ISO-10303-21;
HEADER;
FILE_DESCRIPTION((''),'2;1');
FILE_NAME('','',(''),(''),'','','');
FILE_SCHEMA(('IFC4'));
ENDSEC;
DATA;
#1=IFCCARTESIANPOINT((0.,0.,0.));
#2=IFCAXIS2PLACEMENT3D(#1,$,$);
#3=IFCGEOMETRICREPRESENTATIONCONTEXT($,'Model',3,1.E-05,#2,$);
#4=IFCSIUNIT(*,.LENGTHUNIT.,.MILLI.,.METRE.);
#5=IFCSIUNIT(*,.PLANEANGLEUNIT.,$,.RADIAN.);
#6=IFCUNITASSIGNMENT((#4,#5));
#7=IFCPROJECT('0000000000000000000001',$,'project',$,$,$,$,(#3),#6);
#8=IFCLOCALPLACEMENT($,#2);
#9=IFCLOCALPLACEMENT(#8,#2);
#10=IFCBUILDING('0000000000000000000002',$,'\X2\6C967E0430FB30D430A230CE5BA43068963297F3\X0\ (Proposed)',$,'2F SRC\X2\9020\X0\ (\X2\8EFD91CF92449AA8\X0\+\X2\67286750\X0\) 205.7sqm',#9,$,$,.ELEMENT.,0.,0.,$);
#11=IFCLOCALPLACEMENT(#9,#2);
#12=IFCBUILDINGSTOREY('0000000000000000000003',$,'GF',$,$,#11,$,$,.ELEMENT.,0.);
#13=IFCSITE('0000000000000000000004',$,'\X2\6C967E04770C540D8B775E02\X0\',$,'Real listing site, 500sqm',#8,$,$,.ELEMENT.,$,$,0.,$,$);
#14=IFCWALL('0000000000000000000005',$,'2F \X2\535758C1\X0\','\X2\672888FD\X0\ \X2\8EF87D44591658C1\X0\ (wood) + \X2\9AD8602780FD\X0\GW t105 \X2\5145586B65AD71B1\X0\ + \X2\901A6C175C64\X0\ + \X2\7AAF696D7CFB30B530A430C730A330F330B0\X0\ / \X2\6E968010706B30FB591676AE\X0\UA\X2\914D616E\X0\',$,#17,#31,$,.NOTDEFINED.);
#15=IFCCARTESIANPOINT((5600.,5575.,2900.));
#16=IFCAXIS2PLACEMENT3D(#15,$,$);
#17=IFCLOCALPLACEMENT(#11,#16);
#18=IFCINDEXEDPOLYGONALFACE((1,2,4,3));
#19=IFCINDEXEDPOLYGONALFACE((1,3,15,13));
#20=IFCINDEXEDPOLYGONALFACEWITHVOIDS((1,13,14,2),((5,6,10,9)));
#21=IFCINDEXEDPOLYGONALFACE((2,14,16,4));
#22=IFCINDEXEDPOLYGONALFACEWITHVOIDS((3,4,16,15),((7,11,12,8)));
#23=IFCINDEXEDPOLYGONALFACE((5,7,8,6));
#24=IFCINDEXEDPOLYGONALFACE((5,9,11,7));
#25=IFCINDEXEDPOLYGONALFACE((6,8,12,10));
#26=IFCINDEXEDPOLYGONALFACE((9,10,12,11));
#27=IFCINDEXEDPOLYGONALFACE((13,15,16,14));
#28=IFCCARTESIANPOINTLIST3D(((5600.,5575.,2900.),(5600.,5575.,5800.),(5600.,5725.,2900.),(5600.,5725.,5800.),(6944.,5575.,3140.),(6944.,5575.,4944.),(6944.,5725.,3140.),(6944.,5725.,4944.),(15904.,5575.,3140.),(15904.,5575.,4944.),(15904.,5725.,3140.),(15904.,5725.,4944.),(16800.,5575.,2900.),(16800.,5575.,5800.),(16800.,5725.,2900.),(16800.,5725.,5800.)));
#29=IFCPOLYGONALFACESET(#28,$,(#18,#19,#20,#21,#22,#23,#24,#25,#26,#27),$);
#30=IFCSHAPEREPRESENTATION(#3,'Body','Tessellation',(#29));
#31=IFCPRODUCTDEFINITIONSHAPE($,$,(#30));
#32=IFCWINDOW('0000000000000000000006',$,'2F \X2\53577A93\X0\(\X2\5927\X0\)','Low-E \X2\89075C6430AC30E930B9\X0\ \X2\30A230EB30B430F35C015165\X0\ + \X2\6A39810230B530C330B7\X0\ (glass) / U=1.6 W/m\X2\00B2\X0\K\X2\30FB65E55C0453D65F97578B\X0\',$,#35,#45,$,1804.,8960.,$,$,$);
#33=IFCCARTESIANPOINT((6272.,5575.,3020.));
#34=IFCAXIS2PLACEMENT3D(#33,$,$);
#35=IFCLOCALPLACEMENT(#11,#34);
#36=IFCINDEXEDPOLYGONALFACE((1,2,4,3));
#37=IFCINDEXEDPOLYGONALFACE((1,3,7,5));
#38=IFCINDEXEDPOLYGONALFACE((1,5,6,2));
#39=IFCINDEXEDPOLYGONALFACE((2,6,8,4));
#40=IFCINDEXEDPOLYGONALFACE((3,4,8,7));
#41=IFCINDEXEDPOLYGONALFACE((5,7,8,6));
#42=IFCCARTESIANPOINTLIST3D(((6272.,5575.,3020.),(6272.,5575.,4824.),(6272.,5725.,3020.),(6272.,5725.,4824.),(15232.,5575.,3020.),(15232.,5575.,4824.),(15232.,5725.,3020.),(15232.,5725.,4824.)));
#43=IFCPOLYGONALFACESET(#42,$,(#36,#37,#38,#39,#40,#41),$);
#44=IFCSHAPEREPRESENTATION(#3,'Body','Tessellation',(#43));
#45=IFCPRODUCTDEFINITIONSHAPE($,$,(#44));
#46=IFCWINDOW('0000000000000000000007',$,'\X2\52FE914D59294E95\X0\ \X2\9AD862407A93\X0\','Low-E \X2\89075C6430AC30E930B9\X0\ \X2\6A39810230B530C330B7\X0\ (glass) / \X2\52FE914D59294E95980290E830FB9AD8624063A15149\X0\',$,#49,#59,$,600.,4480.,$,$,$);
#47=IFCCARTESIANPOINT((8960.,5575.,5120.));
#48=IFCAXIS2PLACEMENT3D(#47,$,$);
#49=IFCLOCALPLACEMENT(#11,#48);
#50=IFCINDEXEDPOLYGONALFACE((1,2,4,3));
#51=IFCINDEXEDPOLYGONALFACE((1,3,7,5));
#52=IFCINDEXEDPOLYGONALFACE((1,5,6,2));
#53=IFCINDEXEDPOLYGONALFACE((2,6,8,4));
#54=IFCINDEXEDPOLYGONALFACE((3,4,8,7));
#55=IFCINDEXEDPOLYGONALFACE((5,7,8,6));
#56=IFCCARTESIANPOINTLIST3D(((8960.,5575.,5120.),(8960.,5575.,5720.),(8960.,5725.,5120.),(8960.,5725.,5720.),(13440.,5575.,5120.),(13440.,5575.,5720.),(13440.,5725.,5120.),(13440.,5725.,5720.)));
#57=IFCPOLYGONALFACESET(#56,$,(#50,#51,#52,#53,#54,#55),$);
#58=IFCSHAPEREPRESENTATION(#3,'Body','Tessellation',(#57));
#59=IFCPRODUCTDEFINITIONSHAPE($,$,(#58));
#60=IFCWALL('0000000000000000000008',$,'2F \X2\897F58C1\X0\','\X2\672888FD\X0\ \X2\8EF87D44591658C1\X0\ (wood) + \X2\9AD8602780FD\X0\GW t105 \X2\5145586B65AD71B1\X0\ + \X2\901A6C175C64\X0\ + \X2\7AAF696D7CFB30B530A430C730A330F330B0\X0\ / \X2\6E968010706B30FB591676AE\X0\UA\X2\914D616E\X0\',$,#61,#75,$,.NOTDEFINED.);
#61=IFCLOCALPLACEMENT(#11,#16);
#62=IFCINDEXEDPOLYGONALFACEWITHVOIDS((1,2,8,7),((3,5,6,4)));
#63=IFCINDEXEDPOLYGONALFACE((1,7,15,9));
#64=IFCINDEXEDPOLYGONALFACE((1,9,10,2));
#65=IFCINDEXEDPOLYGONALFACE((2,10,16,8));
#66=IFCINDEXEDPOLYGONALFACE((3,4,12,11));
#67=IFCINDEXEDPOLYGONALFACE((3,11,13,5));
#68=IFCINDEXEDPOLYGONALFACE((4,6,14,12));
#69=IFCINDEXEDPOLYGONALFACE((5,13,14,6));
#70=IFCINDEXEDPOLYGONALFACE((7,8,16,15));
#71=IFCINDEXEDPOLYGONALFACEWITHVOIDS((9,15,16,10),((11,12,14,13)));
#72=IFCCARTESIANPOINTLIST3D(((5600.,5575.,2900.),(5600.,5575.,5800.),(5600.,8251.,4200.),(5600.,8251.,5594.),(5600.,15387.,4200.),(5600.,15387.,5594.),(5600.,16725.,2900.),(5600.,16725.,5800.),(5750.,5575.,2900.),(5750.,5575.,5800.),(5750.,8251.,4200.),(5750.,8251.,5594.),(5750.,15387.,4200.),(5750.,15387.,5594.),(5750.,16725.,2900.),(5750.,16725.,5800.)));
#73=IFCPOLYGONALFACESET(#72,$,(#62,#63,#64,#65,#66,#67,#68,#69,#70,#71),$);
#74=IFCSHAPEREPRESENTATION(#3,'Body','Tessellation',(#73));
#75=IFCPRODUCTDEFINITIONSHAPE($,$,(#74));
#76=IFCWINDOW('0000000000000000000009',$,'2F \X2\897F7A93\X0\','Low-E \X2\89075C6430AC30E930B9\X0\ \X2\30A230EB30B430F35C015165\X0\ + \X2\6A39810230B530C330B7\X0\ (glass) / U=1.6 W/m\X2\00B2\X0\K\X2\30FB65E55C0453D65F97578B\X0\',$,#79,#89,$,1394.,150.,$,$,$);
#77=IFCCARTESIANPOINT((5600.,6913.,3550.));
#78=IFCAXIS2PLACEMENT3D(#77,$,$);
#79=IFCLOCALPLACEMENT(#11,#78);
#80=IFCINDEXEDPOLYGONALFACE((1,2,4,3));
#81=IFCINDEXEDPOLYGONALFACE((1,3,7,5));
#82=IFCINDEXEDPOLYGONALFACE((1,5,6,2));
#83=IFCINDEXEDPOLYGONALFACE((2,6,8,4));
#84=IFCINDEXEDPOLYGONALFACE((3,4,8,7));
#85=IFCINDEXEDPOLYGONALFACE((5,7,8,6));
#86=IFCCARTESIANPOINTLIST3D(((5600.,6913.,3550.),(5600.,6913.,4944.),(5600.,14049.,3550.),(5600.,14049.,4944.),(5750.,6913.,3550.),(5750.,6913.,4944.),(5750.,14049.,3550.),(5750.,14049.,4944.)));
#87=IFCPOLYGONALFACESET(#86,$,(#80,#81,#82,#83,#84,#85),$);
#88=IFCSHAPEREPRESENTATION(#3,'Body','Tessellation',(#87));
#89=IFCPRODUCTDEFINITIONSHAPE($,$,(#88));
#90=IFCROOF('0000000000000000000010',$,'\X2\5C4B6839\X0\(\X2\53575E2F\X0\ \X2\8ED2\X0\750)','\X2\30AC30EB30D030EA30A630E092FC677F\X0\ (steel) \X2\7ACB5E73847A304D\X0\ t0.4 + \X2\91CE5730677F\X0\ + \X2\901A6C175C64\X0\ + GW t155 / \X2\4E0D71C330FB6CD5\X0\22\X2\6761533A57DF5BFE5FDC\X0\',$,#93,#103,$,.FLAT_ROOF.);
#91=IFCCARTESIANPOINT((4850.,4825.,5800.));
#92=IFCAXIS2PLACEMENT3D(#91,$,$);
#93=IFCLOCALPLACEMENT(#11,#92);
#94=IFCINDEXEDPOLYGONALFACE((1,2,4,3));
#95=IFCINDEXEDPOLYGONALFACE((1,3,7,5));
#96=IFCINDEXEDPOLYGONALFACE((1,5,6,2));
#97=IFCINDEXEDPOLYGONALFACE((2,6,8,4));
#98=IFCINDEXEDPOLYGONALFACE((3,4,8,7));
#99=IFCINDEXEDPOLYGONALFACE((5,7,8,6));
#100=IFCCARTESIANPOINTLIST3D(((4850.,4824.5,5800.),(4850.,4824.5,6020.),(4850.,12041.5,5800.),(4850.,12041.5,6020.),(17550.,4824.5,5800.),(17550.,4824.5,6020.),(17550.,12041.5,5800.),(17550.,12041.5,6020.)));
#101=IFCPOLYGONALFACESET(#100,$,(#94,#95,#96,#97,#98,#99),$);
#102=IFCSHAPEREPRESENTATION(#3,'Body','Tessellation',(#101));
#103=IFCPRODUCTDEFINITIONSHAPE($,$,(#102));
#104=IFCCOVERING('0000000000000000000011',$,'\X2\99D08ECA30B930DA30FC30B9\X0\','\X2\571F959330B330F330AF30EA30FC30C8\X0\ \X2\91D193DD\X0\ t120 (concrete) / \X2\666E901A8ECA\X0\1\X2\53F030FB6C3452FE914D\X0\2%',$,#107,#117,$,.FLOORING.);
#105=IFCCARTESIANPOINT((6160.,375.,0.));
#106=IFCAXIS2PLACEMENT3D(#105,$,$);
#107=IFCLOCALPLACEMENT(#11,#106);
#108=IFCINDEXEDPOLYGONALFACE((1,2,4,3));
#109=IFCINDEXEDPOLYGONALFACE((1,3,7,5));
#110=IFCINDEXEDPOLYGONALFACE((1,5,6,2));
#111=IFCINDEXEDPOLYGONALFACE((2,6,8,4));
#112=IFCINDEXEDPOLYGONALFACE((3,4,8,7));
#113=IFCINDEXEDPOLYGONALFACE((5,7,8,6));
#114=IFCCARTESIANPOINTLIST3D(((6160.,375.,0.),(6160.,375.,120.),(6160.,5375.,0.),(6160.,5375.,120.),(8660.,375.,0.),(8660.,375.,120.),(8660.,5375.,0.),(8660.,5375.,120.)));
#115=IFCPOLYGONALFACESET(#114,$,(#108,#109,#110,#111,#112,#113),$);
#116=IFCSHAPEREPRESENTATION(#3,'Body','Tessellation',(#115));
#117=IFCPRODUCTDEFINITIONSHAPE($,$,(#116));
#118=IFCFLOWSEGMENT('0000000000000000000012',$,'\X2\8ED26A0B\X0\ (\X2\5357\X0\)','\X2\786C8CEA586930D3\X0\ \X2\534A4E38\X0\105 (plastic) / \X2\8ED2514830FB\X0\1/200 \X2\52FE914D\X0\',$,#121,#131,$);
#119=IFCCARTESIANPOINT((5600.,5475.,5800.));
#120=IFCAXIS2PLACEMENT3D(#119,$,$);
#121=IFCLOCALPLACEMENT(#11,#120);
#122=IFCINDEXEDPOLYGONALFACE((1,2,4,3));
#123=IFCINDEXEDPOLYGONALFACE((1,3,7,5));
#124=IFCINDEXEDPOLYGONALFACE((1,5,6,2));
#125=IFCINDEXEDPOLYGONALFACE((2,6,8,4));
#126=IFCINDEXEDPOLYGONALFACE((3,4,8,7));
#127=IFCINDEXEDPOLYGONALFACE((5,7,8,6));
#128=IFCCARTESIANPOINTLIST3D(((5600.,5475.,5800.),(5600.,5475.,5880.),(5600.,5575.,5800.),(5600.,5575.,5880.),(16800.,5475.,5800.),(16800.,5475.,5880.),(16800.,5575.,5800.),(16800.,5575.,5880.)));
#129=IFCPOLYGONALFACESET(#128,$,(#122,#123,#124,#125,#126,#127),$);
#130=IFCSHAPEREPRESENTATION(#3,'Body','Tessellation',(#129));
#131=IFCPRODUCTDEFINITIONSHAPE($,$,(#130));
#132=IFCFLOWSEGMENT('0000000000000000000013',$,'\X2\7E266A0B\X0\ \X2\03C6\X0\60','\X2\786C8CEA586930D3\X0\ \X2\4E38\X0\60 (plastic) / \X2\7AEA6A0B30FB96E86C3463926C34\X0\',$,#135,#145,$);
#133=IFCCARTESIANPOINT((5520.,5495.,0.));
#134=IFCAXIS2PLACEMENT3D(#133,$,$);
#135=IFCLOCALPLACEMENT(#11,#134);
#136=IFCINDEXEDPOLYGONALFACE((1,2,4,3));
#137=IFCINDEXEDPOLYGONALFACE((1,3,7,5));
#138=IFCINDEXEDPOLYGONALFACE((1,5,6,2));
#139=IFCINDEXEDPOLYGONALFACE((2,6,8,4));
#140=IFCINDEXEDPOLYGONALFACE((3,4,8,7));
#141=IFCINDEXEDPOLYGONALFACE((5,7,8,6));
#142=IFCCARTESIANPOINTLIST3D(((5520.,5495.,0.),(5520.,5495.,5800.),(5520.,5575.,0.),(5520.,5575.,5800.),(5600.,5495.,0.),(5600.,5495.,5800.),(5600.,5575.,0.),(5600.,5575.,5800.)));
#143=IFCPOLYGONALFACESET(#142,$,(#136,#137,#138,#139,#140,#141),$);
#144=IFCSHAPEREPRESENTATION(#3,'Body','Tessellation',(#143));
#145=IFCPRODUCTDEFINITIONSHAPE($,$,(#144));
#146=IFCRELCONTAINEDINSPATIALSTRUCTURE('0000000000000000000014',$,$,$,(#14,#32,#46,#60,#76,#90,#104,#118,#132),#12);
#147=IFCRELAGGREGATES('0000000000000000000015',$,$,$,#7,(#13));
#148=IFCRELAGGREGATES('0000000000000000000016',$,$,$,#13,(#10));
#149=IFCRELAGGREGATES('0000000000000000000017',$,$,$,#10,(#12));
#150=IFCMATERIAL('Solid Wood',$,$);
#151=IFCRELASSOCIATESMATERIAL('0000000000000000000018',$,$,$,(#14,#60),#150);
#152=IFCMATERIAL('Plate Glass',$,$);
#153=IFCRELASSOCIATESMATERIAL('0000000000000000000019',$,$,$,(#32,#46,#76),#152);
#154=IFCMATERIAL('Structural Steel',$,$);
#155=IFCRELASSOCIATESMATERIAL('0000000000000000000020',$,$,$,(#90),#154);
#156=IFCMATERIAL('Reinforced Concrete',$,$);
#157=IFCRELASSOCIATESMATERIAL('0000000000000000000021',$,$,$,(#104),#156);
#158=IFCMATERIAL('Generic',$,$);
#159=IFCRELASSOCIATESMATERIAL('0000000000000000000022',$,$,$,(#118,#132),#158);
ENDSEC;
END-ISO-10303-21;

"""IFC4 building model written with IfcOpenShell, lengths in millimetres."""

from ifc_helpers import new_model, si_unit, frame, frame_2d, origin, place, context, project, spatial, rectangle, extrude, material, element, fill, save


model = new_model("IFC4")

# Units and contexts
model_context = context("Model", 3, precision=1e-05, world=origin())
ifc_project = project(units=[si_unit("LENGTHUNIT", "METRE", prefix="MILLI"), si_unit("PLANEANGLEUNIT", "RADIAN")], contexts=[model_context])

# Site, building, storey
site_placement = place(None, origin())
site = spatial("IfcSite", under=ifc_project, at=site_placement, Name="沖縄県名護市", ObjectType="Real listing site, 500sqm", CompositionType="ELEMENT", RefElevation=0.0)
building_placement = place(site_placement, origin())
building = spatial("IfcBuilding", under=site, at=building_placement, Name="沖縄・ピアノ室と防音 (Proposed)", ObjectType="2F SRC造 (軽量鉄骨+木材) 205.7sqm", CompositionType="ELEMENT", ElevationOfRefHeight=0.0, ElevationOfTerrain=0.0)
storey_placement = place(building_placement, origin())
storey = spatial("IfcBuildingStorey", under=building, at=storey_placement, Name="GF", CompositionType="ELEMENT", Elevation=0.0)

# Shared definitions
ifc_material_1 = material(Name="Solid Wood")

# Shared definitions
ifc_material_2 = material(Name="Reinforced Concrete")

# Shared definitions
ifc_material_3 = material(Name="Plate Glass")

# Wall, openings, windows
wall_1_placement = place(storey_placement, frame((5600.0, 5575.0, 2900.0)))
wall_1 = element("IfcWall", 1, at=wall_1_placement, inside=storey, material=ifc_material_1, Name="2F 南壁", Description="木製 軸組外壁 (wood) + 高性能GW t105 充填断熱 + 通気層 + 窯業系サイディング / 準耐火・外皮UA配慮", PredefinedType="NOTDEFINED", context=model_context, shape_type="SweptSolid", body=[
    extrude(rectangle(XDim=11200.0, YDim=150.0, at=frame_2d((5600.0, 75.0))), frame((5600.0, 5575.0, 2900.0)), (0.0, 0.0, 1.0), 2900.0),
])
opening_1_placement = place(storey_placement, frame((6272.0, 5575.0, 3020.0)))
opening_1 = element("IfcOpeningElement", 2, at=opening_1_placement, cuts=wall_1, PredefinedType="NOTDEFINED", context=model_context, shape_type="SweptSolid", body=[
    extrude(rectangle(XDim=8960.0, YDim=150.0, at=frame_2d((4480.0, 75.0))), frame((6272.0, 5575.0, 3020.0)), (0.0, 0.0, 1.0), 1804.0),
])
opening_2_placement = place(storey_placement, frame((8960.0, 5575.0, 5120.0)))
opening_2 = element("IfcOpeningElement", 3, at=opening_2_placement, cuts=wall_1, PredefinedType="NOTDEFINED", context=model_context, shape_type="SweptSolid", body=[
    extrude(rectangle(XDim=4480.0, YDim=150.0, at=frame_2d((2240.0, 75.0))), frame((8960.0, 5575.0, 5120.0)), (0.0, 0.0, 1.0), 600.0),
])
window_1_placement = place(storey_placement, frame((6272.0, 5575.0, 3020.0)))
window_1 = element("IfcWindow", 4, at=window_1_placement, inside=storey, material=ifc_material_3, Name="2F 南窓(大)", Description="Low-E 複層ガラス アルゴン封入 + 樹脂サッシ (glass) / U=1.6 W/m²K・日射取得型", OverallHeight=1804.0, OverallWidth=8960.0, context=model_context, shape_type="SweptSolid", body=[
    extrude(rectangle(XDim=8960.0, YDim=150.0, at=frame_2d((4480.0, 75.0))), frame((6272.0, 5575.0, 3020.0)), (0.0, 0.0, 1.0), 1804.0),
])
fill(opening_1, window_1)
window_2_placement = place(storey_placement, frame((8960.0, 5575.0, 5120.0)))
window_2 = element("IfcWindow", 5, at=window_2_placement, inside=storey, material=ifc_material_3, Name="勾配天井 高所窓", Description="Low-E 複層ガラス 樹脂サッシ (glass) / 勾配天井頂部・高所採光", OverallHeight=600.0, OverallWidth=4480.0, context=model_context, shape_type="SweptSolid", body=[
    extrude(rectangle(XDim=4480.0, YDim=150.0, at=frame_2d((2240.0, 75.0))), frame((8960.0, 5575.0, 5120.0)), (0.0, 0.0, 1.0), 600.0),
])
fill(opening_2, window_2)

# Wall, opening, window
wall_2_placement = place(storey_placement, frame((5600.0, 5575.0, 2900.0)))
wall_2 = element("IfcWall", 6, at=wall_2_placement, inside=storey, material=ifc_material_1, Name="2F 西壁", Description="木製 軸組外壁 (wood) + 高性能GW t105 充填断熱 + 通気層 + 窯業系サイディング / 準耐火・外皮UA配慮", PredefinedType="NOTDEFINED", context=model_context, shape_type="SweptSolid", body=[
    extrude(rectangle(XDim=150.0, YDim=11150.0, at=frame_2d((75.0, 5575.0))), frame((5600.0, 5575.0, 2900.0)), (0.0, 0.0, 1.0), 2900.0),
])
opening_3_placement = place(storey_placement, frame((5600.0, 6913.0, 3550.0)))
opening_3 = element("IfcOpeningElement", 7, at=opening_3_placement, cuts=wall_2, PredefinedType="NOTDEFINED", context=model_context, shape_type="SweptSolid", body=[
    extrude(rectangle(XDim=150.0, YDim=7136.0, at=frame_2d((75.0, 3568.0))), frame((5600.0, 6913.0, 3550.0)), (0.0, 0.0, 1.0), 1394.0),
])
window_3_placement = place(storey_placement, frame((5600.0, 6913.0, 3550.0)))
window_3 = element("IfcWindow", 8, at=window_3_placement, inside=storey, material=ifc_material_3, Name="2F 西窓", Description="Low-E 複層ガラス アルゴン封入 + 樹脂サッシ (glass) / U=1.6 W/m²K・日射取得型", OverallHeight=1394.0, OverallWidth=150.0, context=model_context, shape_type="SweptSolid", body=[
    extrude(rectangle(XDim=150.0, YDim=7136.0, at=frame_2d((75.0, 3568.0))), frame((5600.0, 6913.0, 3550.0)), (0.0, 0.0, 1.0), 1394.0),
])
fill(opening_3, window_3)

# Roof
ifc_material_4 = material(Name="Structural Steel")
for number, where, name in (
    (9, (4850.0, 4825.0, 5800.0), "屋根(南帯 軒750)"),
):
    element("IfcRoof", number, at=place(storey_placement, frame(where)), inside=storey, material=ifc_material_4, Name=name, Description="ガルバリウム鋼板 (steel) 立平葺き t0.4 + 野地板 + 通気層 + GW t155 / 不燃・法22条区域対応", PredefinedType="FLAT_ROOF", context=model_context, shape_type="SweptSolid", body=[
        extrude(rectangle(XDim=12700.0, YDim=7217.0, at=frame_2d((6350.0, 3608.0))), frame((4850.0, 4825.0, 5800.0)), (0.0, 0.0, 1.0), 220.0),
    ])

# Covering
covering_placement = place(storey_placement, frame((6160.0, 375.0, 0.0)))
element("IfcCovering", 10, at=covering_placement, inside=storey, material=ifc_material_2, Name="駐車スペース", Description="土間コンクリート 金鏝 t120 (concrete) / 普通車1台・水勾配2%", PredefinedType="FLOORING", context=model_context, shape_type="SweptSolid", body=[
    extrude(rectangle(XDim=2500.0, YDim=5000.0, at=frame_2d((1250.0, 2500.0))), frame((6160.0, 375.0, 0.0)), (0.0, 0.0, 1.0), 120.0),
])

# Flow segments
ifc_material_5 = material(Name="Generic")
flow_segment_1_placement = place(storey_placement, frame((5600.0, 5475.0, 5800.0)))
element("IfcFlowSegment", 11, at=flow_segment_1_placement, inside=storey, material=ifc_material_5, Name="軒樋 (南)", Description="硬質塩ビ 半丸105 (plastic) / 軒先・1/200 勾配", context=model_context, shape_type="SweptSolid", body=[
    extrude(rectangle(XDim=11200.0, YDim=100.0, at=frame_2d((5600.0, 50.0))), frame((5600.0, 5475.0, 5800.0)), (0.0, 0.0, 1.0), 80.0),
])
flow_segment_2_placement = place(storey_placement, frame((5520.0, 5495.0, 0.0)))
element("IfcFlowSegment", 12, at=flow_segment_2_placement, inside=storey, material=ifc_material_5, Name="縦樋 φ60", Description="硬質塩ビ 丸60 (plastic) / 竪樋・雨水排水", context=model_context, shape_type="SweptSolid", body=[
    extrude(rectangle(XDim=80.0, YDim=80.0, at=frame_2d((40.0, 40.0))), frame((5520.0, 5495.0, 0.0)), (0.0, 0.0, 1.0), 5800.0),
])

save(model, "model.ifc")
